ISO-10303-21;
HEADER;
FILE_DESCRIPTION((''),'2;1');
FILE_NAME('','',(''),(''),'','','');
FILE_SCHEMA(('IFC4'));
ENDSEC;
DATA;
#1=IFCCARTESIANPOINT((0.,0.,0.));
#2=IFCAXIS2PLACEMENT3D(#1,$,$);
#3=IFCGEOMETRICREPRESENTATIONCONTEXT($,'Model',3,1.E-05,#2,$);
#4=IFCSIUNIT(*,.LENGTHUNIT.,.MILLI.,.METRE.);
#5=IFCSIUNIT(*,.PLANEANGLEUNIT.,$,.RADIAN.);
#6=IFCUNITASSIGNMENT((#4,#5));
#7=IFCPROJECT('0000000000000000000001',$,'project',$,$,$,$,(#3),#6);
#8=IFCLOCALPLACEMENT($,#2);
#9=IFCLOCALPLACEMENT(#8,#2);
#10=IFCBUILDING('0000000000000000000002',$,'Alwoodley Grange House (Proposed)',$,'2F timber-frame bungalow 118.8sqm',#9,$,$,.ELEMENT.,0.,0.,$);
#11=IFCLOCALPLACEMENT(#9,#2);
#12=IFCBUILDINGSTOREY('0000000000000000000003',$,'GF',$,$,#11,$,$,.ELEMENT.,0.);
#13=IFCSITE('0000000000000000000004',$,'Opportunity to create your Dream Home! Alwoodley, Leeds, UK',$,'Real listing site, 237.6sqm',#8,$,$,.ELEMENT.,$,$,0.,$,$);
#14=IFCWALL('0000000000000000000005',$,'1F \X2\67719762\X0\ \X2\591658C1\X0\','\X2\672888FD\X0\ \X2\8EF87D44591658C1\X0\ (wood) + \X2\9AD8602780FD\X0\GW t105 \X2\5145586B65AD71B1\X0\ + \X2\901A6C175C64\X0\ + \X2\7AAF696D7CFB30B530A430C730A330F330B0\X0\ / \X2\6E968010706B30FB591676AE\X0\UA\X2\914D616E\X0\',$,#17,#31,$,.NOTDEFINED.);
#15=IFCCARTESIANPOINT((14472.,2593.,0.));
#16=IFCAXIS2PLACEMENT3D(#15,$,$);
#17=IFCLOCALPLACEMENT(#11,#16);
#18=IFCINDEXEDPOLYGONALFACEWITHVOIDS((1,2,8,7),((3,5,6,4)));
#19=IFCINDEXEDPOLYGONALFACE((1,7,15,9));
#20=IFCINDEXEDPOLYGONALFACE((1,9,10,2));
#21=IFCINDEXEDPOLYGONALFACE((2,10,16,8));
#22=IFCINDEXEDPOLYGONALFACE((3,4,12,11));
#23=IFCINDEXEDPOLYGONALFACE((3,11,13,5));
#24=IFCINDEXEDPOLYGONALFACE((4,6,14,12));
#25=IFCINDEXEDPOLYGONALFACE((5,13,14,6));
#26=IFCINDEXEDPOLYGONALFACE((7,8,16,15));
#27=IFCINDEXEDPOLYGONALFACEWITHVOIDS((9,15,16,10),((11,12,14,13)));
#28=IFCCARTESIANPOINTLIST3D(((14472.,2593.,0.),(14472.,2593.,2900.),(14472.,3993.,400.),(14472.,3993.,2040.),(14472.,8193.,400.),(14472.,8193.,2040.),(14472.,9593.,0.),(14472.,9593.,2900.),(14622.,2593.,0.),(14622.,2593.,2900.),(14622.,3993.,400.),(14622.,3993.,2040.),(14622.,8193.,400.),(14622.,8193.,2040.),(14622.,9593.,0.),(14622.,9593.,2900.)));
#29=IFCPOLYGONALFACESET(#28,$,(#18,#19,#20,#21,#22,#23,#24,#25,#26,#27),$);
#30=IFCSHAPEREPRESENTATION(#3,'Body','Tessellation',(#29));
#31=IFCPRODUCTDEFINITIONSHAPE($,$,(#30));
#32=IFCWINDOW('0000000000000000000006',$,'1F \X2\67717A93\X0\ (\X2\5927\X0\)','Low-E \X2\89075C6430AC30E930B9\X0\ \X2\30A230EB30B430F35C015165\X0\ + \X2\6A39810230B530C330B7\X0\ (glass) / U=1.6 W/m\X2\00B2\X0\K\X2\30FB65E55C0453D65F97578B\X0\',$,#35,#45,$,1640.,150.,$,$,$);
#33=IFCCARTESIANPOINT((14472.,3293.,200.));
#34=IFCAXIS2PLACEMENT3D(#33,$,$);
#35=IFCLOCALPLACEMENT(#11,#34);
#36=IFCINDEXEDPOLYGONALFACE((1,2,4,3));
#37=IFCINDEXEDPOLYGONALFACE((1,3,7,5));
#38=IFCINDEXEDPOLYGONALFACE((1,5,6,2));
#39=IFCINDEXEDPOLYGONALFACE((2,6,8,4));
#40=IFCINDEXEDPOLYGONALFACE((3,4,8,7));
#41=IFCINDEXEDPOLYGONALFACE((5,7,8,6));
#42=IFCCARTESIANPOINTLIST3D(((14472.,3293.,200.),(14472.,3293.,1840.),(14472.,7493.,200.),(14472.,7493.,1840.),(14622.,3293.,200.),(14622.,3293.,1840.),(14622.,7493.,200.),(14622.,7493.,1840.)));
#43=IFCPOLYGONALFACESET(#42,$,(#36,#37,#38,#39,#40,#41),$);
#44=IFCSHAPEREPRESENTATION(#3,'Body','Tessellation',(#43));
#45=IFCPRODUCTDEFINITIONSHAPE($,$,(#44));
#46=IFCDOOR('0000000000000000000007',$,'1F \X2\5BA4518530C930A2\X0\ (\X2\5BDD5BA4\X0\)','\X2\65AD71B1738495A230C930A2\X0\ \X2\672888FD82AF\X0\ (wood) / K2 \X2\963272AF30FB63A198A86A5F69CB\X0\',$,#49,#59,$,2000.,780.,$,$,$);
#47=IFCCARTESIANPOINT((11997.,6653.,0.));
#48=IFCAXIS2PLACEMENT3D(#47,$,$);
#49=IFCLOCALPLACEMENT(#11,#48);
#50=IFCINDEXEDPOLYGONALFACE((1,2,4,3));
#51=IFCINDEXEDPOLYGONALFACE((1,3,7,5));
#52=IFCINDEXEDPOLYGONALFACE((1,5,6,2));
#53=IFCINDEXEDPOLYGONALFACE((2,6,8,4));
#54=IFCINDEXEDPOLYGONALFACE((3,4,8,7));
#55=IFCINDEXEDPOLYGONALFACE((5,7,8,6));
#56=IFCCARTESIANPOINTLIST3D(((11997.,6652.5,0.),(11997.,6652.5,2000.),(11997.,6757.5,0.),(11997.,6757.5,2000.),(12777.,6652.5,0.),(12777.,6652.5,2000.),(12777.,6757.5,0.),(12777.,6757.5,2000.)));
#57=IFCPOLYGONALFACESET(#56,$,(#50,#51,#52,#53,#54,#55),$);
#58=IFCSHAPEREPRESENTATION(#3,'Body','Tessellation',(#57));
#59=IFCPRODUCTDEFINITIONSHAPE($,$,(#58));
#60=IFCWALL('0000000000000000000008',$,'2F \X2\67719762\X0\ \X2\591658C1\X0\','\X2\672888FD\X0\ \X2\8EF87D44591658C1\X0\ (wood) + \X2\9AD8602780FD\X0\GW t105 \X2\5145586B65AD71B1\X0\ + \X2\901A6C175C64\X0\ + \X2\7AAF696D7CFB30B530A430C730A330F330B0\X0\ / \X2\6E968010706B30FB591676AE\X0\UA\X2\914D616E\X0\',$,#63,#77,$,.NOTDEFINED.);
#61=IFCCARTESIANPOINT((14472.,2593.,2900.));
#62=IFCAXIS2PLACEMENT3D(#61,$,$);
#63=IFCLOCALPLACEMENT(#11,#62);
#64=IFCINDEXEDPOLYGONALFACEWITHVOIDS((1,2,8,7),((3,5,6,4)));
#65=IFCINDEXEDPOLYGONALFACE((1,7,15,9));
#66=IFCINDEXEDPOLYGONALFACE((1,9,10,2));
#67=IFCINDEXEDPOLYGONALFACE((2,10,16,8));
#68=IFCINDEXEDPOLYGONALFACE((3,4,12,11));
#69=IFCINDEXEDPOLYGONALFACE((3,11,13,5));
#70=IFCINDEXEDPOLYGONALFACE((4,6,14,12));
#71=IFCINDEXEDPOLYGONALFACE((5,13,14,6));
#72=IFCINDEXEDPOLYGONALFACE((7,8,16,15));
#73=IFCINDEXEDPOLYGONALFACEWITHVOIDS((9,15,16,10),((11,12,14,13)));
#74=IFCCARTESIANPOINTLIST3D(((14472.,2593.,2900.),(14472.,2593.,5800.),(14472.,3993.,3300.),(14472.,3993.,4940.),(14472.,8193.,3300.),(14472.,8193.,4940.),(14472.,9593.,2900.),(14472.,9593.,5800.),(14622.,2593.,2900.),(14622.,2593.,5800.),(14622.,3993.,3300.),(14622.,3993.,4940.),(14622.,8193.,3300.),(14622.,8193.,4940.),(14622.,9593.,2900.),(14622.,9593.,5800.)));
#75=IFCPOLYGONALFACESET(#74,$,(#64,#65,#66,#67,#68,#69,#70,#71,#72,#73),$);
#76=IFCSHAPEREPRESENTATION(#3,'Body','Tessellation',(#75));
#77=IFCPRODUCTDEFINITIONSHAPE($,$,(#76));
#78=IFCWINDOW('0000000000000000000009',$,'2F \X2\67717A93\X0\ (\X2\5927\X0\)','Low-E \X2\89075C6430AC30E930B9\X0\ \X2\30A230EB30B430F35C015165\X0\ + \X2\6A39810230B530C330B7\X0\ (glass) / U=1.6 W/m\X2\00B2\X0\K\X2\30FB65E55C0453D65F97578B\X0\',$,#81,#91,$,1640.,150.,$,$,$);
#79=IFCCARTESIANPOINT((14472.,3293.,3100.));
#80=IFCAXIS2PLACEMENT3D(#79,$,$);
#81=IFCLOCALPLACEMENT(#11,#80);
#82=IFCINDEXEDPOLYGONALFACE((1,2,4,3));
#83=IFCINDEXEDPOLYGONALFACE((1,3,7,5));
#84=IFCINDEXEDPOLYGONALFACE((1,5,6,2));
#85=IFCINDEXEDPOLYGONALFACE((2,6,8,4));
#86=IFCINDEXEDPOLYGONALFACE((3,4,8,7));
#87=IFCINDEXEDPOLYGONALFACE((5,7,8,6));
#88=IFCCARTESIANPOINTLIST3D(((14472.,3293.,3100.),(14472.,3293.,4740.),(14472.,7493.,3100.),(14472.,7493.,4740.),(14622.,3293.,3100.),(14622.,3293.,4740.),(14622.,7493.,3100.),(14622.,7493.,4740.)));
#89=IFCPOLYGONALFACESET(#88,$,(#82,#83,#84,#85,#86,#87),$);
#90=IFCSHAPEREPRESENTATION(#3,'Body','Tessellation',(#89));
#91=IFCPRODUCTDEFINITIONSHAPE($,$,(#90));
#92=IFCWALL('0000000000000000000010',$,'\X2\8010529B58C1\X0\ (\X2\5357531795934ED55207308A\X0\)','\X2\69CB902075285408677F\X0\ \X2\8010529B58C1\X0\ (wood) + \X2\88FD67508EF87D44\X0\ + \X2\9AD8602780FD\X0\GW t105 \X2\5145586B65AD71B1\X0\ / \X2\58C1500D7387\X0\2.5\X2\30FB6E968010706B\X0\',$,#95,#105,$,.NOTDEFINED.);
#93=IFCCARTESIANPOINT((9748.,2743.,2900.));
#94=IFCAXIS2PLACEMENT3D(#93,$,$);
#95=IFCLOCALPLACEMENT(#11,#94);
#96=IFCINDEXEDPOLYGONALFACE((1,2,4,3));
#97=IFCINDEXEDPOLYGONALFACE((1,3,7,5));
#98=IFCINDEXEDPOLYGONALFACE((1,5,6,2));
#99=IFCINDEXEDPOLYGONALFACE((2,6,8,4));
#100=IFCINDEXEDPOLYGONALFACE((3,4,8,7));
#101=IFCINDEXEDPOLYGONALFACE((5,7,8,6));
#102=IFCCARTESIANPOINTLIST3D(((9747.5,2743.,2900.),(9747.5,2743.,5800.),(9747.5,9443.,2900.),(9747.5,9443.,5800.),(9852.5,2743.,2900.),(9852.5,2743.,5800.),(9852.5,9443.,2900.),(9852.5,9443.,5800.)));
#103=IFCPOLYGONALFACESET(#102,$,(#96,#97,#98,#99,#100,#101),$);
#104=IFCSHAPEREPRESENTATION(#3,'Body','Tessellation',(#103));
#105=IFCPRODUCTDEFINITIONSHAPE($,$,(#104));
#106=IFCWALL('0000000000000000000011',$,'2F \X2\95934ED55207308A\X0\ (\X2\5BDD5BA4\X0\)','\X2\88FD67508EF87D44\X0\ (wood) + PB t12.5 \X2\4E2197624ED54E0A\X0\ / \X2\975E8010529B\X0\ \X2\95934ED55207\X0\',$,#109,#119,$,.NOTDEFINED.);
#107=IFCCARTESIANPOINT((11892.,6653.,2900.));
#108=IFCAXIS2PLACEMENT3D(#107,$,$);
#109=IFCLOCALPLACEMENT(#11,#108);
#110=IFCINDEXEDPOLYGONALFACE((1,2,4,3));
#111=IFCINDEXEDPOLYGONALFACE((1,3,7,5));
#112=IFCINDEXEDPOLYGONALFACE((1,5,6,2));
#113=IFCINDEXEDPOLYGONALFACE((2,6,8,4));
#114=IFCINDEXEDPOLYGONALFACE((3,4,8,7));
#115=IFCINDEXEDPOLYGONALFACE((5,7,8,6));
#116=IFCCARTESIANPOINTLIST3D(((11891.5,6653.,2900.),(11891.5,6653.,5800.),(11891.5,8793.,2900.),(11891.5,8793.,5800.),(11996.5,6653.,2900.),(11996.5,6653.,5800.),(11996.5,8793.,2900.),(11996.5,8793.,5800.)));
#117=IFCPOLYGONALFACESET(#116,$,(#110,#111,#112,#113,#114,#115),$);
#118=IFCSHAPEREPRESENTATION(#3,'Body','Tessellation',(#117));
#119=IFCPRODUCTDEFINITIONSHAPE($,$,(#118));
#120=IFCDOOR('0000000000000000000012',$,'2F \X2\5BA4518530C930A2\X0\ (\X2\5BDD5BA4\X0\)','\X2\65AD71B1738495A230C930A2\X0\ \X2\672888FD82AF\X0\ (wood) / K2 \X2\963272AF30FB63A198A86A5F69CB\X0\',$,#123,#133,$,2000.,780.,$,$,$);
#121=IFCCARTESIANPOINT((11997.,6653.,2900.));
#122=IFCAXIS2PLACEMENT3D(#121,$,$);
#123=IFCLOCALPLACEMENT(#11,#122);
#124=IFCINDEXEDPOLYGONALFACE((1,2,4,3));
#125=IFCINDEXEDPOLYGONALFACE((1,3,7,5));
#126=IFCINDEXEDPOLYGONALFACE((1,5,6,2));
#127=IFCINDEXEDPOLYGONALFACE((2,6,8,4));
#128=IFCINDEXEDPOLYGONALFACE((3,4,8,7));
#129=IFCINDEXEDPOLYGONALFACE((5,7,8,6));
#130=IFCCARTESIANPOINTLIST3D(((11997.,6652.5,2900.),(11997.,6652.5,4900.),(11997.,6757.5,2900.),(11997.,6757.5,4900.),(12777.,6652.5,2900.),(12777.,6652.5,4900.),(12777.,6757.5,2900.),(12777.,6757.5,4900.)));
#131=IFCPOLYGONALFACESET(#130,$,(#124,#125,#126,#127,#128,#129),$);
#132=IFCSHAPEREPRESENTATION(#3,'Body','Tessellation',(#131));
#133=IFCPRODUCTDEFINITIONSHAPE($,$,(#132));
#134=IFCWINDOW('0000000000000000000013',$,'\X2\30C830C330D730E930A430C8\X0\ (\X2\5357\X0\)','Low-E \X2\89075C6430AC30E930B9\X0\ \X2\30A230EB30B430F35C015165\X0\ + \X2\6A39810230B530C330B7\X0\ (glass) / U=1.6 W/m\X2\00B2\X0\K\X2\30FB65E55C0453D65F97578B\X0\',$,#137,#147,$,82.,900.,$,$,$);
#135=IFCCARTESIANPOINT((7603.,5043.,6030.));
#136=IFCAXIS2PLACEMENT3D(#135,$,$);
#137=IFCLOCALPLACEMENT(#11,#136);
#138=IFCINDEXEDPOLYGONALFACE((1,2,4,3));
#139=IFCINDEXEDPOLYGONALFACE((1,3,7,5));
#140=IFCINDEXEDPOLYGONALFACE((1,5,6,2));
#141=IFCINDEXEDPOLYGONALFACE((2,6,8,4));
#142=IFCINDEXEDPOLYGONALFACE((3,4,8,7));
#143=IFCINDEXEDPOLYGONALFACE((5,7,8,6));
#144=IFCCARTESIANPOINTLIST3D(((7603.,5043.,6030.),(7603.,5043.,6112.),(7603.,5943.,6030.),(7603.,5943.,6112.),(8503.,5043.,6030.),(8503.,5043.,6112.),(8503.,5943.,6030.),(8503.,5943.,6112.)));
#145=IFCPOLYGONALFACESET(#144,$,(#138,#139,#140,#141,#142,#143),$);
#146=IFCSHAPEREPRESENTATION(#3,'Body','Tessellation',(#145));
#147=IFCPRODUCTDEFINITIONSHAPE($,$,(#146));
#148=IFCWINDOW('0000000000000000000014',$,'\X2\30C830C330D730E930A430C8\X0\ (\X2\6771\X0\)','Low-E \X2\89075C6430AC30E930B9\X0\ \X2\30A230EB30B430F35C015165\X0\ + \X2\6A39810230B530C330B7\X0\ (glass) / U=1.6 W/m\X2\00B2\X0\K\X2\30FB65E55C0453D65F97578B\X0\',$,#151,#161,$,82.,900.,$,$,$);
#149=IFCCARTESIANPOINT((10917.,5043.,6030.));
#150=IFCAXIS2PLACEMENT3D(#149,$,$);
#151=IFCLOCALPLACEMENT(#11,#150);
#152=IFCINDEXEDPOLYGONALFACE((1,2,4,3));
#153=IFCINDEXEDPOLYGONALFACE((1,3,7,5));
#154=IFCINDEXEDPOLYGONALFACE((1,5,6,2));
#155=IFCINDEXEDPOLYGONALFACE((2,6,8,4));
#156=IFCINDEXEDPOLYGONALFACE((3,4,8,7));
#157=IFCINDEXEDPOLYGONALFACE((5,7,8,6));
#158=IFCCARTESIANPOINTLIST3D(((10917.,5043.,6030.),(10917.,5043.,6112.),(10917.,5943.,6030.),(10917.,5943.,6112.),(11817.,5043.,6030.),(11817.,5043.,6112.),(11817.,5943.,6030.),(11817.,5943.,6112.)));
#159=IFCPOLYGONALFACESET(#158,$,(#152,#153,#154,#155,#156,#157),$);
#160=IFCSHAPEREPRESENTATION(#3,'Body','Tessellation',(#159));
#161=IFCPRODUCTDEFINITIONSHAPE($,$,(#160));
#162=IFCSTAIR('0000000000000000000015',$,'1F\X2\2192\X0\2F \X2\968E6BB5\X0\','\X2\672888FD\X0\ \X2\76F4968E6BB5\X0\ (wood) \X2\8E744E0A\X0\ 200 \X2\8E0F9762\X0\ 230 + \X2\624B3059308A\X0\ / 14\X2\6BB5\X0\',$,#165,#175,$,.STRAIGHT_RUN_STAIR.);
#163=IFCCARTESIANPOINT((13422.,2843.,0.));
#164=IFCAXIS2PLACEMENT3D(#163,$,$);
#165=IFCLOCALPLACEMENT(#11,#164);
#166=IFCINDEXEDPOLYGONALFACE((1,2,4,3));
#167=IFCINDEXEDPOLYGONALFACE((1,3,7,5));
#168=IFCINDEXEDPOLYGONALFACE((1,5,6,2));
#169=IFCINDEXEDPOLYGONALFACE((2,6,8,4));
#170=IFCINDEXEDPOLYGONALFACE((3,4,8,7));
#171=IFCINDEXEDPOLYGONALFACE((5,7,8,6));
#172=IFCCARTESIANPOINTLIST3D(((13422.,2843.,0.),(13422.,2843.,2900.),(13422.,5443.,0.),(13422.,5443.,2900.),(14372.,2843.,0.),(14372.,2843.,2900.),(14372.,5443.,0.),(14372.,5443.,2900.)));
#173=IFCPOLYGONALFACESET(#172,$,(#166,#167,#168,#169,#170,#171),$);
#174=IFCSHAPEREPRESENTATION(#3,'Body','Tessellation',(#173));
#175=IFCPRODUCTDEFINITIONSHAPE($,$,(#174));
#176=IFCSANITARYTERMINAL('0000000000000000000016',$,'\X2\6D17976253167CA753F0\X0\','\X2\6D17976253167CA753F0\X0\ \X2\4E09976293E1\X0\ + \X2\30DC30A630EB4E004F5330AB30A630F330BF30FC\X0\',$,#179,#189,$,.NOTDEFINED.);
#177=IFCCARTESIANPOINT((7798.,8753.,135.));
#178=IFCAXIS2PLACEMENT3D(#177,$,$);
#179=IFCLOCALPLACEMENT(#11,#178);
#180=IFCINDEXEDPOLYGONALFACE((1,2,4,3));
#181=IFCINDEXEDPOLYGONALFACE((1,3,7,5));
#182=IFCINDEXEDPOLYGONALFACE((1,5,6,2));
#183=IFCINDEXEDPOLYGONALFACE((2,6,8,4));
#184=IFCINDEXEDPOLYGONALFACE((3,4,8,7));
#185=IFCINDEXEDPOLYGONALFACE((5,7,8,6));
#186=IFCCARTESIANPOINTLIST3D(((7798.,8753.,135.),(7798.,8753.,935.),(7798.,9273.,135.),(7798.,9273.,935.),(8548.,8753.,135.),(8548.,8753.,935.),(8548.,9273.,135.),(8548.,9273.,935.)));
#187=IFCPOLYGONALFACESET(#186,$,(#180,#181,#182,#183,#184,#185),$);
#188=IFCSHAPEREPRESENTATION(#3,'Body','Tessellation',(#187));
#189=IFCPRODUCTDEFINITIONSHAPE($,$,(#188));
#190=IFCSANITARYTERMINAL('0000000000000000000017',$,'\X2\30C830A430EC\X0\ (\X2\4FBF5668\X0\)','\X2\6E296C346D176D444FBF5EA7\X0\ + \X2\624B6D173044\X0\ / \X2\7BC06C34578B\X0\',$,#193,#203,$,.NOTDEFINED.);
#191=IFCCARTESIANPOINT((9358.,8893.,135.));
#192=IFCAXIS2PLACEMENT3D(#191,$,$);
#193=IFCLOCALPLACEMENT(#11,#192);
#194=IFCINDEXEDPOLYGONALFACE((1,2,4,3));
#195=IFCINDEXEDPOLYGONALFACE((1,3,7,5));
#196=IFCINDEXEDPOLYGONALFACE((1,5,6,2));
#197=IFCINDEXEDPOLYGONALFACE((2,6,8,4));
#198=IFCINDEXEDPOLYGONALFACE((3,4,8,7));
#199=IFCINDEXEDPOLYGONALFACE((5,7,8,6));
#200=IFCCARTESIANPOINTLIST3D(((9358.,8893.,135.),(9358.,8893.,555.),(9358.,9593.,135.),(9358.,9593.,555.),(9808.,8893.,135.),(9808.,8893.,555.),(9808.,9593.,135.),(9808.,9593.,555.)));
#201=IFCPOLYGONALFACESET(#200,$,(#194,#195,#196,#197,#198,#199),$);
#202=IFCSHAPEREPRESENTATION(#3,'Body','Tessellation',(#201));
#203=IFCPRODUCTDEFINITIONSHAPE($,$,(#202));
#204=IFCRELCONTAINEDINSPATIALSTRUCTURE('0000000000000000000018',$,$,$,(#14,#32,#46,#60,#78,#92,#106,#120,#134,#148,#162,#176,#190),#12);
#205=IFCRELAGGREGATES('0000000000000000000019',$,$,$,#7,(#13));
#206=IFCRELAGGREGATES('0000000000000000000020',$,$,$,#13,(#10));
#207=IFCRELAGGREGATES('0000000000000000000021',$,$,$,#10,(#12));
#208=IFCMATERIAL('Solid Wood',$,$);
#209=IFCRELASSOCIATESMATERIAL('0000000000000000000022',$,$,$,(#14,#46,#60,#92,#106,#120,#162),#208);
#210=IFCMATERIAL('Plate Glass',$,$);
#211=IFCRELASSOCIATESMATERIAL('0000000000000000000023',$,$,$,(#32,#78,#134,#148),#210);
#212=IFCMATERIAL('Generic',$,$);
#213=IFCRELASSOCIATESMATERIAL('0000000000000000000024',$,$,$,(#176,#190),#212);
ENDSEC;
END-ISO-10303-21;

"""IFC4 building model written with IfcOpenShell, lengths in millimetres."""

from ifc_helpers import new_model, si_unit, frame, frame_2d, origin, place, context, project, spatial, rectangle, extrude, material, element, fill, save


model = new_model("IFC4")

# Units and contexts
model_context = context("Model", 3, precision=1e-05, world=origin())
ifc_project = project(units=[si_unit("LENGTHUNIT", "METRE", prefix="MILLI"), si_unit("PLANEANGLEUNIT", "RADIAN")], contexts=[model_context])

# Site, building, storey
site_placement = place(None, origin())
site = spatial("IfcSite", under=ifc_project, at=site_placement, Name="Opportunity to create your Dream Home! Alwoodley, Leeds, UK", ObjectType="Real listing site, 237.6sqm", CompositionType="ELEMENT", RefElevation=0.0)
building_placement = place(site_placement, origin())
building = spatial("IfcBuilding", under=site, at=building_placement, Name="Alwoodley Grange House (Proposed)", ObjectType="2F timber-frame bungalow 118.8sqm", CompositionType="ELEMENT", ElevationOfRefHeight=0.0, ElevationOfTerrain=0.0)
storey_placement = place(building_placement, origin())
storey = spatial("IfcBuildingStorey", under=building, at=storey_placement, Name="GF", CompositionType="ELEMENT", Elevation=0.0)

# Wall, opening, window
ifc_material_1 = material(Name="Solid Wood")
wall_1_placement = place(storey_placement, frame((14472.0, 2593.0, 0.0)))
wall_1 = element("IfcWall", 1, at=wall_1_placement, inside=storey, material=ifc_material_1, Name="1F 東面 外壁", Description="木製 軸組外壁 (wood) + 高性能GW t105 充填断熱 + 通気層 + 窯業系サイディング / 準耐火・外皮UA配慮", PredefinedType="NOTDEFINED", context=model_context, shape_type="SweptSolid", body=[
    extrude(rectangle(XDim=150.0, YDim=7000.0, at=frame_2d((75.0, 3500.0))), frame((14472.0, 2593.0, 0.0)), (0.0, 0.0, 1.0), 2900.0),
])
opening_1_placement = place(storey_placement, frame((14472.0, 3293.0, 200.0)))
opening_1 = element("IfcOpeningElement", 2, at=opening_1_placement, cuts=wall_1, PredefinedType="NOTDEFINED", context=model_context, shape_type="SweptSolid", body=[
    extrude(rectangle(XDim=150.0, YDim=4200.0, at=frame_2d((75.0, 2100.0))), frame((14472.0, 3293.0, 200.0)), (0.0, 0.0, 1.0), 1640.0),
])
ifc_material_2 = material(Name="Plate Glass")
window_1_placement = place(storey_placement, frame((14472.0, 3293.0, 200.0)))
window_1 = element("IfcWindow", 3, at=window_1_placement, inside=storey, material=ifc_material_2, Name="1F 東窓 (大)", Description="Low-E 複層ガラス アルゴン封入 + 樹脂サッシ (glass) / U=1.6 W/m²K・日射取得型", OverallHeight=1640.0, OverallWidth=150.0, context=model_context, shape_type="SweptSolid", body=[
    extrude(rectangle(XDim=150.0, YDim=4200.0, at=frame_2d((75.0, 2100.0))), frame((14472.0, 3293.0, 200.0)), (0.0, 0.0, 1.0), 1640.0),
])
fill(opening_1, window_1)

# Door
door_1_placement = place(storey_placement, frame((11997.0, 6653.0, 0.0)))
element("IfcDoor", 4, at=door_1_placement, inside=storey, material=ifc_material_1, Name="1F 室内ドア (寝室)", Description="断熱玄関ドア 木製芯 (wood) / K2 防犯・採風機構", OverallHeight=2000.0, OverallWidth=780.0, context=model_context, shape_type="SweptSolid", body=[
    extrude(rectangle(XDim=780.0, YDim=105.0, at=frame_2d((390.0, 52.0))), frame((11997.0, 6653.0, 0.0)), (0.0, 0.0, 1.0), 2000.0),
])

# Wall, opening, window
wall_2_placement = place(storey_placement, frame((14472.0, 2593.0, 2900.0)))
wall_2 = element("IfcWall", 5, at=wall_2_placement, inside=storey, material=ifc_material_1, Name="2F 東面 外壁", Description="木製 軸組外壁 (wood) + 高性能GW t105 充填断熱 + 通気層 + 窯業系サイディング / 準耐火・外皮UA配慮", PredefinedType="NOTDEFINED", context=model_context, shape_type="SweptSolid", body=[
    extrude(rectangle(XDim=150.0, YDim=7000.0, at=frame_2d((75.0, 3500.0))), frame((14472.0, 2593.0, 2900.0)), (0.0, 0.0, 1.0), 2900.0),
])
opening_2_placement = place(storey_placement, frame((14472.0, 3293.0, 3100.0)))
opening_2 = element("IfcOpeningElement", 6, at=opening_2_placement, cuts=wall_2, PredefinedType="NOTDEFINED", context=model_context, shape_type="SweptSolid", body=[
    extrude(rectangle(XDim=150.0, YDim=4200.0, at=frame_2d((75.0, 2100.0))), frame((14472.0, 3293.0, 3100.0)), (0.0, 0.0, 1.0), 1640.0),
])
window_2_placement = place(storey_placement, frame((14472.0, 3293.0, 3100.0)))
window_2 = element("IfcWindow", 7, at=window_2_placement, inside=storey, material=ifc_material_2, Name="2F 東窓 (大)", Description="Low-E 複層ガラス アルゴン封入 + 樹脂サッシ (glass) / U=1.6 W/m²K・日射取得型", OverallHeight=1640.0, OverallWidth=150.0, context=model_context, shape_type="SweptSolid", body=[
    extrude(rectangle(XDim=150.0, YDim=4200.0, at=frame_2d((75.0, 2100.0))), frame((14472.0, 3293.0, 3100.0)), (0.0, 0.0, 1.0), 1640.0),
])
fill(opening_2, window_2)

# Walls
wall_3_placement = place(storey_placement, frame((9748.0, 2743.0, 2900.0)))
element("IfcWall", 8, at=wall_3_placement, inside=storey, material=ifc_material_1, Name="耐力壁 (南北間仕切り)", Description="構造用合板 耐力壁 (wood) + 製材軸組 + 高性能GW t105 充填断熱 / 壁倍率2.5・準耐火", PredefinedType="NOTDEFINED", context=model_context, shape_type="SweptSolid", body=[
    extrude(rectangle(XDim=105.0, YDim=6700.0, at=frame_2d((52.0, 3350.0))), frame((9748.0, 2743.0, 2900.0)), (0.0, 0.0, 1.0), 2900.0),
])
wall_4_placement = place(storey_placement, frame((11892.0, 6653.0, 2900.0)))
element("IfcWall", 9, at=wall_4_placement, inside=storey, material=ifc_material_1, Name="2F 間仕切り (寝室)", Description="製材軸組 (wood) + PB t12.5 両面仕上 / 非耐力 間仕切", PredefinedType="NOTDEFINED", context=model_context, shape_type="SweptSolid", body=[
    extrude(rectangle(XDim=105.0, YDim=2140.0, at=frame_2d((52.0, 1070.0))), frame((11892.0, 6653.0, 2900.0)), (0.0, 0.0, 1.0), 2900.0),
])

# Door
door_2_placement = place(storey_placement, frame((11997.0, 6653.0, 2900.0)))
element("IfcDoor", 10, at=door_2_placement, inside=storey, material=ifc_material_1, Name="2F 室内ドア (寝室)", Description="断熱玄関ドア 木製芯 (wood) / K2 防犯・採風機構", OverallHeight=2000.0, OverallWidth=780.0, context=model_context, shape_type="SweptSolid", body=[
    extrude(rectangle(XDim=780.0, YDim=105.0, at=frame_2d((390.0, 52.0))), frame((11997.0, 6653.0, 2900.0)), (0.0, 0.0, 1.0), 2000.0),
])

# Windows
window_3_placement = place(storey_placement, frame((7603.0, 5043.0, 6030.0)))
element("IfcWindow", 11, at=window_3_placement, inside=storey, material=ifc_material_2, Name="トップライト (南)", Description="Low-E 複層ガラス アルゴン封入 + 樹脂サッシ (glass) / U=1.6 W/m²K・日射取得型", OverallHeight=82.0, OverallWidth=900.0, context=model_context, shape_type="SweptSolid", body=[
    extrude(rectangle(XDim=900.0, YDim=900.0, at=frame_2d((450.0, 450.0))), frame((7603.0, 5043.0, 6030.0)), (0.0, 0.0, 1.0), 82.0),
])
window_4_placement = place(storey_placement, frame((10917.0, 5043.0, 6030.0)))
element("IfcWindow", 12, at=window_4_placement, inside=storey, material=ifc_material_2, Name="トップライト (東)", Description="Low-E 複層ガラス アルゴン封入 + 樹脂サッシ (glass) / U=1.6 W/m²K・日射取得型", OverallHeight=82.0, OverallWidth=900.0, context=model_context, shape_type="SweptSolid", body=[
    extrude(rectangle(XDim=900.0, YDim=900.0, at=frame_2d((450.0, 450.0))), frame((10917.0, 5043.0, 6030.0)), (0.0, 0.0, 1.0), 82.0),
])

# Stair
stair_placement = place(storey_placement, frame((13422.0, 2843.0, 0.0)))
element("IfcStair", 13, at=stair_placement, inside=storey, material=ifc_material_1, Name="1F→2F 階段", Description="木製 直階段 (wood) 蹴上 200 踏面 230 + 手すり / 14段", PredefinedType="STRAIGHT_RUN_STAIR", context=model_context, shape_type="SweptSolid", body=[
    extrude(rectangle(XDim=950.0, YDim=2600.0, at=frame_2d((475.0, 1300.0))), frame((13422.0, 2843.0, 0.0)), (0.0, 0.0, 1.0), 2900.0),
])

# Sanitary terminals
ifc_material_3 = material(Name="Generic")
sanitary_terminal_1_placement = place(storey_placement, frame((7798.0, 8753.0, 135.0)))
element("IfcSanitaryTerminal", 14, at=sanitary_terminal_1_placement, inside=storey, material=ifc_material_3, Name="洗面化粧台", Description="洗面化粧台 三面鏡 + ボウル一体カウンター", PredefinedType="NOTDEFINED", context=model_context, shape_type="SweptSolid", body=[
    extrude(rectangle(XDim=750.0, YDim=520.0, at=frame_2d((375.0, 260.0))), frame((7798.0, 8753.0, 135.0)), (0.0, 0.0, 1.0), 800.0),
])
sanitary_terminal_2_placement = place(storey_placement, frame((9358.0, 8893.0, 135.0)))
element("IfcSanitaryTerminal", 15, at=sanitary_terminal_2_placement, inside=storey, material=ifc_material_3, Name="トイレ (便器)", Description="温水洗浄便座 + 手洗い / 節水型", PredefinedType="NOTDEFINED", context=model_context, shape_type="SweptSolid", body=[
    extrude(rectangle(XDim=450.0, YDim=700.0, at=frame_2d((225.0, 350.0))), frame((9358.0, 8893.0, 135.0)), (0.0, 0.0, 1.0), 420.0),
])

save(model, "model.ifc")
